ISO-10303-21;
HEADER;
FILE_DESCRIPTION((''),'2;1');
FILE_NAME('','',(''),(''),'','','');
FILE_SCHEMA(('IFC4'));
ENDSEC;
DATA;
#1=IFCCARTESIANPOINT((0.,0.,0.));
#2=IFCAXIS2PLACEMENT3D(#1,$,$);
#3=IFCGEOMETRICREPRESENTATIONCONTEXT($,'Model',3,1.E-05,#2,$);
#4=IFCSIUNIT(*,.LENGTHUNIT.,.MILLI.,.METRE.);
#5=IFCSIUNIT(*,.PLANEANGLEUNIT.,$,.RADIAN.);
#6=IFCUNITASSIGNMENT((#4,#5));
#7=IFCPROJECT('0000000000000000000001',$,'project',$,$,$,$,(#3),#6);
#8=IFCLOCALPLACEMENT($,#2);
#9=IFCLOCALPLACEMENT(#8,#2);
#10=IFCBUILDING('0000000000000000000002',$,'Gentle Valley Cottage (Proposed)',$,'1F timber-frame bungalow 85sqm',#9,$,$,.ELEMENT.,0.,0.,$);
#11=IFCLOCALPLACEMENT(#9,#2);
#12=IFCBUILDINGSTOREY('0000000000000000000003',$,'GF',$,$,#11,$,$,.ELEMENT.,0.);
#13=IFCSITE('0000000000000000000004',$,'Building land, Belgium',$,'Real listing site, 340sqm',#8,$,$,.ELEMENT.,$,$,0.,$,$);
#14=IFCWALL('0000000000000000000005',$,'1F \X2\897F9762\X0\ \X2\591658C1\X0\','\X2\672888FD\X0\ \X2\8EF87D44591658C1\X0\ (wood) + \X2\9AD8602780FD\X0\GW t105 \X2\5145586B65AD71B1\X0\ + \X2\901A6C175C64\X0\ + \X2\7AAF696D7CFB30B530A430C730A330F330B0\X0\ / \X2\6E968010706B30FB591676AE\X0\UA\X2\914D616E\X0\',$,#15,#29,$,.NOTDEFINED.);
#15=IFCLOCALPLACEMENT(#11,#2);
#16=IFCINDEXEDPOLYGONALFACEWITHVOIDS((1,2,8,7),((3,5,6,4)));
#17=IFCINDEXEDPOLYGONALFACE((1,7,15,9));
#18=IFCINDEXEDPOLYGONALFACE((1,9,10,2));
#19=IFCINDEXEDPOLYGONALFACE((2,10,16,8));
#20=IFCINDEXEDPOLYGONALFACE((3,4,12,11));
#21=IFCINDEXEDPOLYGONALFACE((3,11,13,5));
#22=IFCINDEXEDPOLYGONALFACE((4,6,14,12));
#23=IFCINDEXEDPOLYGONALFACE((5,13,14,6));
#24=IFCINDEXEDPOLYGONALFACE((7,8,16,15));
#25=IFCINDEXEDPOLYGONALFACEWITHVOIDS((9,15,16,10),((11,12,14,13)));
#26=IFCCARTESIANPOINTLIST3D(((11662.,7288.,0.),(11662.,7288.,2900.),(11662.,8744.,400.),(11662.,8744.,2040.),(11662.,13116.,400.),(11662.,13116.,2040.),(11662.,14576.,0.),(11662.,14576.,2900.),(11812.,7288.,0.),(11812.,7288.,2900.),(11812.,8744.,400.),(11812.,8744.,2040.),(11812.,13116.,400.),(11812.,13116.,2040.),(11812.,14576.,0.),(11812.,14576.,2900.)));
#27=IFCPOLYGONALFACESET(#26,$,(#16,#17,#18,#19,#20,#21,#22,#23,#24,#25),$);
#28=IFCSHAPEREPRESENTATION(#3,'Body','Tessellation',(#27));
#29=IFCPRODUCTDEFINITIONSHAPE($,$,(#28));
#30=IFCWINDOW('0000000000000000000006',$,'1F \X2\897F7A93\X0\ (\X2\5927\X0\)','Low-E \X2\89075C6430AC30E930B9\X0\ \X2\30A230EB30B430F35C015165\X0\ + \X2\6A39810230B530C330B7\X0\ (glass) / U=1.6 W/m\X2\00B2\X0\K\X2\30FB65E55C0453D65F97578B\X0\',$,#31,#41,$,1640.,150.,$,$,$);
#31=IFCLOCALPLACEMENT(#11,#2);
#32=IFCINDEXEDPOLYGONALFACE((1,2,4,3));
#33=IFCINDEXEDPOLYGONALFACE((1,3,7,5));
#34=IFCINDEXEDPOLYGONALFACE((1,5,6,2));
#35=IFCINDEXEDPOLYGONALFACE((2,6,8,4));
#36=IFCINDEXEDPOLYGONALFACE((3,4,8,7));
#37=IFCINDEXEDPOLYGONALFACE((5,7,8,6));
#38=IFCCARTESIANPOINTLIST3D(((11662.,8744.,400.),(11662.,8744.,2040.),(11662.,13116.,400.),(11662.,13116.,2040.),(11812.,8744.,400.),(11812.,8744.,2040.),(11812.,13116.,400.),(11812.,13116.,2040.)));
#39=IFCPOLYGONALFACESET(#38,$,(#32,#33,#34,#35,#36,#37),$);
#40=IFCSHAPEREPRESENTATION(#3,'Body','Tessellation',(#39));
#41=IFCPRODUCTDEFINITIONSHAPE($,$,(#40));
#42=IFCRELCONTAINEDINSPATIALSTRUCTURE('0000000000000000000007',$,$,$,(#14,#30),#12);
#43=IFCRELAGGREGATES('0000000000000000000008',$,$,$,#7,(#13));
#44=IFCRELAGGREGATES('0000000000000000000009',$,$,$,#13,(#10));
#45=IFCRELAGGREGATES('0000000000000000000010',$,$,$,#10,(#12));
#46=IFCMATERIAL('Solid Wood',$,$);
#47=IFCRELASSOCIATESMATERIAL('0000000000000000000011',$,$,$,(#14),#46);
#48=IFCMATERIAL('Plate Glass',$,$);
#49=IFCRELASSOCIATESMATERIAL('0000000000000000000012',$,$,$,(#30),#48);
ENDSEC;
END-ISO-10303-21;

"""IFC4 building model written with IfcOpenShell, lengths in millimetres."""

from ifc_helpers import new_model, si_unit, frame, frame_2d, origin, place, context, project, spatial, rectangle, extrude, material, element, fill, save


model = new_model("IFC4")

# Units and contexts
model_context = context("Model", 3, precision=1e-05, world=origin())
ifc_project = project(units=[si_unit("LENGTHUNIT", "METRE", prefix="MILLI"), si_unit("PLANEANGLEUNIT", "RADIAN")], contexts=[model_context])

# Site, building, storey
site_placement = place(None, origin())
site = spatial("IfcSite", under=ifc_project, at=site_placement, Name="Building land, Belgium", ObjectType="Real listing site, 340sqm", CompositionType="ELEMENT", RefElevation=0.0)
building_placement = place(site_placement, origin())
building = spatial("IfcBuilding", under=site, at=building_placement, Name="Gentle Valley Cottage (Proposed)", ObjectType="1F timber-frame bungalow 85sqm", CompositionType="ELEMENT", ElevationOfRefHeight=0.0, ElevationOfTerrain=0.0)
storey_placement = place(building_placement, origin())
storey = spatial("IfcBuildingStorey", under=building, at=storey_placement, Name="GF", CompositionType="ELEMENT", Elevation=0.0)

# Shared definitions
ifc_material_1 = material(Name="Solid Wood")

# Shared definitions
ifc_material_2 = material(Name="Plate Glass")

# Wall, opening, window
wall_1_placement = place(storey_placement, frame((5831.0, 3644.0, 0.0)))
wall_1 = element("IfcWall", 1, at=wall_1_placement, inside=storey, material=ifc_material_1, Name="1F 西面 外壁", Description="木製 軸組外壁 (wood) + 高性能GW t105 充填断熱 + 通気層 + 窯業系サイディング / 準耐火・外皮UA配慮", PredefinedType="NOTDEFINED", context=model_context, shape_type="SweptSolid", body=[
    extrude(rectangle(XDim=150.0, YDim=7288.0, at=frame_2d((75.0, 3644.0))), frame((5831.0, 3644.0, 0.0)), (0.0, 0.0, 1.0), 2900.0),
])
opening_1_placement = place(storey_placement, frame((5831.0, 4372.0, 200.0)))
opening_1 = element("IfcOpeningElement", 2, at=opening_1_placement, cuts=wall_1, PredefinedType="NOTDEFINED", context=model_context, shape_type="SweptSolid", body=[
    extrude(rectangle(XDim=150.0, YDim=4372.0, at=frame_2d((75.0, 2186.0))), frame((5831.0, 4372.0, 200.0)), (0.0, 0.0, 1.0), 1640.0),
])
window_1_placement = place(storey_placement, frame((5831.0, 4372.0, 200.0)))
window_1 = element("IfcWindow", 3, at=window_1_placement, inside=storey, material=ifc_material_2, Name="1F 西窓 (大)", Description="Low-E 複層ガラス アルゴン封入 + 樹脂サッシ (glass) / U=1.6 W/m²K・日射取得型", OverallHeight=1640.0, OverallWidth=150.0, context=model_context, shape_type="SweptSolid", body=[
    extrude(rectangle(XDim=150.0, YDim=4372.0, at=frame_2d((75.0, 2186.0))), frame((5831.0, 4372.0, 200.0)), (0.0, 0.0, 1.0), 1640.0),
])
fill(opening_1, window_1)

save(model, "model.ifc")
